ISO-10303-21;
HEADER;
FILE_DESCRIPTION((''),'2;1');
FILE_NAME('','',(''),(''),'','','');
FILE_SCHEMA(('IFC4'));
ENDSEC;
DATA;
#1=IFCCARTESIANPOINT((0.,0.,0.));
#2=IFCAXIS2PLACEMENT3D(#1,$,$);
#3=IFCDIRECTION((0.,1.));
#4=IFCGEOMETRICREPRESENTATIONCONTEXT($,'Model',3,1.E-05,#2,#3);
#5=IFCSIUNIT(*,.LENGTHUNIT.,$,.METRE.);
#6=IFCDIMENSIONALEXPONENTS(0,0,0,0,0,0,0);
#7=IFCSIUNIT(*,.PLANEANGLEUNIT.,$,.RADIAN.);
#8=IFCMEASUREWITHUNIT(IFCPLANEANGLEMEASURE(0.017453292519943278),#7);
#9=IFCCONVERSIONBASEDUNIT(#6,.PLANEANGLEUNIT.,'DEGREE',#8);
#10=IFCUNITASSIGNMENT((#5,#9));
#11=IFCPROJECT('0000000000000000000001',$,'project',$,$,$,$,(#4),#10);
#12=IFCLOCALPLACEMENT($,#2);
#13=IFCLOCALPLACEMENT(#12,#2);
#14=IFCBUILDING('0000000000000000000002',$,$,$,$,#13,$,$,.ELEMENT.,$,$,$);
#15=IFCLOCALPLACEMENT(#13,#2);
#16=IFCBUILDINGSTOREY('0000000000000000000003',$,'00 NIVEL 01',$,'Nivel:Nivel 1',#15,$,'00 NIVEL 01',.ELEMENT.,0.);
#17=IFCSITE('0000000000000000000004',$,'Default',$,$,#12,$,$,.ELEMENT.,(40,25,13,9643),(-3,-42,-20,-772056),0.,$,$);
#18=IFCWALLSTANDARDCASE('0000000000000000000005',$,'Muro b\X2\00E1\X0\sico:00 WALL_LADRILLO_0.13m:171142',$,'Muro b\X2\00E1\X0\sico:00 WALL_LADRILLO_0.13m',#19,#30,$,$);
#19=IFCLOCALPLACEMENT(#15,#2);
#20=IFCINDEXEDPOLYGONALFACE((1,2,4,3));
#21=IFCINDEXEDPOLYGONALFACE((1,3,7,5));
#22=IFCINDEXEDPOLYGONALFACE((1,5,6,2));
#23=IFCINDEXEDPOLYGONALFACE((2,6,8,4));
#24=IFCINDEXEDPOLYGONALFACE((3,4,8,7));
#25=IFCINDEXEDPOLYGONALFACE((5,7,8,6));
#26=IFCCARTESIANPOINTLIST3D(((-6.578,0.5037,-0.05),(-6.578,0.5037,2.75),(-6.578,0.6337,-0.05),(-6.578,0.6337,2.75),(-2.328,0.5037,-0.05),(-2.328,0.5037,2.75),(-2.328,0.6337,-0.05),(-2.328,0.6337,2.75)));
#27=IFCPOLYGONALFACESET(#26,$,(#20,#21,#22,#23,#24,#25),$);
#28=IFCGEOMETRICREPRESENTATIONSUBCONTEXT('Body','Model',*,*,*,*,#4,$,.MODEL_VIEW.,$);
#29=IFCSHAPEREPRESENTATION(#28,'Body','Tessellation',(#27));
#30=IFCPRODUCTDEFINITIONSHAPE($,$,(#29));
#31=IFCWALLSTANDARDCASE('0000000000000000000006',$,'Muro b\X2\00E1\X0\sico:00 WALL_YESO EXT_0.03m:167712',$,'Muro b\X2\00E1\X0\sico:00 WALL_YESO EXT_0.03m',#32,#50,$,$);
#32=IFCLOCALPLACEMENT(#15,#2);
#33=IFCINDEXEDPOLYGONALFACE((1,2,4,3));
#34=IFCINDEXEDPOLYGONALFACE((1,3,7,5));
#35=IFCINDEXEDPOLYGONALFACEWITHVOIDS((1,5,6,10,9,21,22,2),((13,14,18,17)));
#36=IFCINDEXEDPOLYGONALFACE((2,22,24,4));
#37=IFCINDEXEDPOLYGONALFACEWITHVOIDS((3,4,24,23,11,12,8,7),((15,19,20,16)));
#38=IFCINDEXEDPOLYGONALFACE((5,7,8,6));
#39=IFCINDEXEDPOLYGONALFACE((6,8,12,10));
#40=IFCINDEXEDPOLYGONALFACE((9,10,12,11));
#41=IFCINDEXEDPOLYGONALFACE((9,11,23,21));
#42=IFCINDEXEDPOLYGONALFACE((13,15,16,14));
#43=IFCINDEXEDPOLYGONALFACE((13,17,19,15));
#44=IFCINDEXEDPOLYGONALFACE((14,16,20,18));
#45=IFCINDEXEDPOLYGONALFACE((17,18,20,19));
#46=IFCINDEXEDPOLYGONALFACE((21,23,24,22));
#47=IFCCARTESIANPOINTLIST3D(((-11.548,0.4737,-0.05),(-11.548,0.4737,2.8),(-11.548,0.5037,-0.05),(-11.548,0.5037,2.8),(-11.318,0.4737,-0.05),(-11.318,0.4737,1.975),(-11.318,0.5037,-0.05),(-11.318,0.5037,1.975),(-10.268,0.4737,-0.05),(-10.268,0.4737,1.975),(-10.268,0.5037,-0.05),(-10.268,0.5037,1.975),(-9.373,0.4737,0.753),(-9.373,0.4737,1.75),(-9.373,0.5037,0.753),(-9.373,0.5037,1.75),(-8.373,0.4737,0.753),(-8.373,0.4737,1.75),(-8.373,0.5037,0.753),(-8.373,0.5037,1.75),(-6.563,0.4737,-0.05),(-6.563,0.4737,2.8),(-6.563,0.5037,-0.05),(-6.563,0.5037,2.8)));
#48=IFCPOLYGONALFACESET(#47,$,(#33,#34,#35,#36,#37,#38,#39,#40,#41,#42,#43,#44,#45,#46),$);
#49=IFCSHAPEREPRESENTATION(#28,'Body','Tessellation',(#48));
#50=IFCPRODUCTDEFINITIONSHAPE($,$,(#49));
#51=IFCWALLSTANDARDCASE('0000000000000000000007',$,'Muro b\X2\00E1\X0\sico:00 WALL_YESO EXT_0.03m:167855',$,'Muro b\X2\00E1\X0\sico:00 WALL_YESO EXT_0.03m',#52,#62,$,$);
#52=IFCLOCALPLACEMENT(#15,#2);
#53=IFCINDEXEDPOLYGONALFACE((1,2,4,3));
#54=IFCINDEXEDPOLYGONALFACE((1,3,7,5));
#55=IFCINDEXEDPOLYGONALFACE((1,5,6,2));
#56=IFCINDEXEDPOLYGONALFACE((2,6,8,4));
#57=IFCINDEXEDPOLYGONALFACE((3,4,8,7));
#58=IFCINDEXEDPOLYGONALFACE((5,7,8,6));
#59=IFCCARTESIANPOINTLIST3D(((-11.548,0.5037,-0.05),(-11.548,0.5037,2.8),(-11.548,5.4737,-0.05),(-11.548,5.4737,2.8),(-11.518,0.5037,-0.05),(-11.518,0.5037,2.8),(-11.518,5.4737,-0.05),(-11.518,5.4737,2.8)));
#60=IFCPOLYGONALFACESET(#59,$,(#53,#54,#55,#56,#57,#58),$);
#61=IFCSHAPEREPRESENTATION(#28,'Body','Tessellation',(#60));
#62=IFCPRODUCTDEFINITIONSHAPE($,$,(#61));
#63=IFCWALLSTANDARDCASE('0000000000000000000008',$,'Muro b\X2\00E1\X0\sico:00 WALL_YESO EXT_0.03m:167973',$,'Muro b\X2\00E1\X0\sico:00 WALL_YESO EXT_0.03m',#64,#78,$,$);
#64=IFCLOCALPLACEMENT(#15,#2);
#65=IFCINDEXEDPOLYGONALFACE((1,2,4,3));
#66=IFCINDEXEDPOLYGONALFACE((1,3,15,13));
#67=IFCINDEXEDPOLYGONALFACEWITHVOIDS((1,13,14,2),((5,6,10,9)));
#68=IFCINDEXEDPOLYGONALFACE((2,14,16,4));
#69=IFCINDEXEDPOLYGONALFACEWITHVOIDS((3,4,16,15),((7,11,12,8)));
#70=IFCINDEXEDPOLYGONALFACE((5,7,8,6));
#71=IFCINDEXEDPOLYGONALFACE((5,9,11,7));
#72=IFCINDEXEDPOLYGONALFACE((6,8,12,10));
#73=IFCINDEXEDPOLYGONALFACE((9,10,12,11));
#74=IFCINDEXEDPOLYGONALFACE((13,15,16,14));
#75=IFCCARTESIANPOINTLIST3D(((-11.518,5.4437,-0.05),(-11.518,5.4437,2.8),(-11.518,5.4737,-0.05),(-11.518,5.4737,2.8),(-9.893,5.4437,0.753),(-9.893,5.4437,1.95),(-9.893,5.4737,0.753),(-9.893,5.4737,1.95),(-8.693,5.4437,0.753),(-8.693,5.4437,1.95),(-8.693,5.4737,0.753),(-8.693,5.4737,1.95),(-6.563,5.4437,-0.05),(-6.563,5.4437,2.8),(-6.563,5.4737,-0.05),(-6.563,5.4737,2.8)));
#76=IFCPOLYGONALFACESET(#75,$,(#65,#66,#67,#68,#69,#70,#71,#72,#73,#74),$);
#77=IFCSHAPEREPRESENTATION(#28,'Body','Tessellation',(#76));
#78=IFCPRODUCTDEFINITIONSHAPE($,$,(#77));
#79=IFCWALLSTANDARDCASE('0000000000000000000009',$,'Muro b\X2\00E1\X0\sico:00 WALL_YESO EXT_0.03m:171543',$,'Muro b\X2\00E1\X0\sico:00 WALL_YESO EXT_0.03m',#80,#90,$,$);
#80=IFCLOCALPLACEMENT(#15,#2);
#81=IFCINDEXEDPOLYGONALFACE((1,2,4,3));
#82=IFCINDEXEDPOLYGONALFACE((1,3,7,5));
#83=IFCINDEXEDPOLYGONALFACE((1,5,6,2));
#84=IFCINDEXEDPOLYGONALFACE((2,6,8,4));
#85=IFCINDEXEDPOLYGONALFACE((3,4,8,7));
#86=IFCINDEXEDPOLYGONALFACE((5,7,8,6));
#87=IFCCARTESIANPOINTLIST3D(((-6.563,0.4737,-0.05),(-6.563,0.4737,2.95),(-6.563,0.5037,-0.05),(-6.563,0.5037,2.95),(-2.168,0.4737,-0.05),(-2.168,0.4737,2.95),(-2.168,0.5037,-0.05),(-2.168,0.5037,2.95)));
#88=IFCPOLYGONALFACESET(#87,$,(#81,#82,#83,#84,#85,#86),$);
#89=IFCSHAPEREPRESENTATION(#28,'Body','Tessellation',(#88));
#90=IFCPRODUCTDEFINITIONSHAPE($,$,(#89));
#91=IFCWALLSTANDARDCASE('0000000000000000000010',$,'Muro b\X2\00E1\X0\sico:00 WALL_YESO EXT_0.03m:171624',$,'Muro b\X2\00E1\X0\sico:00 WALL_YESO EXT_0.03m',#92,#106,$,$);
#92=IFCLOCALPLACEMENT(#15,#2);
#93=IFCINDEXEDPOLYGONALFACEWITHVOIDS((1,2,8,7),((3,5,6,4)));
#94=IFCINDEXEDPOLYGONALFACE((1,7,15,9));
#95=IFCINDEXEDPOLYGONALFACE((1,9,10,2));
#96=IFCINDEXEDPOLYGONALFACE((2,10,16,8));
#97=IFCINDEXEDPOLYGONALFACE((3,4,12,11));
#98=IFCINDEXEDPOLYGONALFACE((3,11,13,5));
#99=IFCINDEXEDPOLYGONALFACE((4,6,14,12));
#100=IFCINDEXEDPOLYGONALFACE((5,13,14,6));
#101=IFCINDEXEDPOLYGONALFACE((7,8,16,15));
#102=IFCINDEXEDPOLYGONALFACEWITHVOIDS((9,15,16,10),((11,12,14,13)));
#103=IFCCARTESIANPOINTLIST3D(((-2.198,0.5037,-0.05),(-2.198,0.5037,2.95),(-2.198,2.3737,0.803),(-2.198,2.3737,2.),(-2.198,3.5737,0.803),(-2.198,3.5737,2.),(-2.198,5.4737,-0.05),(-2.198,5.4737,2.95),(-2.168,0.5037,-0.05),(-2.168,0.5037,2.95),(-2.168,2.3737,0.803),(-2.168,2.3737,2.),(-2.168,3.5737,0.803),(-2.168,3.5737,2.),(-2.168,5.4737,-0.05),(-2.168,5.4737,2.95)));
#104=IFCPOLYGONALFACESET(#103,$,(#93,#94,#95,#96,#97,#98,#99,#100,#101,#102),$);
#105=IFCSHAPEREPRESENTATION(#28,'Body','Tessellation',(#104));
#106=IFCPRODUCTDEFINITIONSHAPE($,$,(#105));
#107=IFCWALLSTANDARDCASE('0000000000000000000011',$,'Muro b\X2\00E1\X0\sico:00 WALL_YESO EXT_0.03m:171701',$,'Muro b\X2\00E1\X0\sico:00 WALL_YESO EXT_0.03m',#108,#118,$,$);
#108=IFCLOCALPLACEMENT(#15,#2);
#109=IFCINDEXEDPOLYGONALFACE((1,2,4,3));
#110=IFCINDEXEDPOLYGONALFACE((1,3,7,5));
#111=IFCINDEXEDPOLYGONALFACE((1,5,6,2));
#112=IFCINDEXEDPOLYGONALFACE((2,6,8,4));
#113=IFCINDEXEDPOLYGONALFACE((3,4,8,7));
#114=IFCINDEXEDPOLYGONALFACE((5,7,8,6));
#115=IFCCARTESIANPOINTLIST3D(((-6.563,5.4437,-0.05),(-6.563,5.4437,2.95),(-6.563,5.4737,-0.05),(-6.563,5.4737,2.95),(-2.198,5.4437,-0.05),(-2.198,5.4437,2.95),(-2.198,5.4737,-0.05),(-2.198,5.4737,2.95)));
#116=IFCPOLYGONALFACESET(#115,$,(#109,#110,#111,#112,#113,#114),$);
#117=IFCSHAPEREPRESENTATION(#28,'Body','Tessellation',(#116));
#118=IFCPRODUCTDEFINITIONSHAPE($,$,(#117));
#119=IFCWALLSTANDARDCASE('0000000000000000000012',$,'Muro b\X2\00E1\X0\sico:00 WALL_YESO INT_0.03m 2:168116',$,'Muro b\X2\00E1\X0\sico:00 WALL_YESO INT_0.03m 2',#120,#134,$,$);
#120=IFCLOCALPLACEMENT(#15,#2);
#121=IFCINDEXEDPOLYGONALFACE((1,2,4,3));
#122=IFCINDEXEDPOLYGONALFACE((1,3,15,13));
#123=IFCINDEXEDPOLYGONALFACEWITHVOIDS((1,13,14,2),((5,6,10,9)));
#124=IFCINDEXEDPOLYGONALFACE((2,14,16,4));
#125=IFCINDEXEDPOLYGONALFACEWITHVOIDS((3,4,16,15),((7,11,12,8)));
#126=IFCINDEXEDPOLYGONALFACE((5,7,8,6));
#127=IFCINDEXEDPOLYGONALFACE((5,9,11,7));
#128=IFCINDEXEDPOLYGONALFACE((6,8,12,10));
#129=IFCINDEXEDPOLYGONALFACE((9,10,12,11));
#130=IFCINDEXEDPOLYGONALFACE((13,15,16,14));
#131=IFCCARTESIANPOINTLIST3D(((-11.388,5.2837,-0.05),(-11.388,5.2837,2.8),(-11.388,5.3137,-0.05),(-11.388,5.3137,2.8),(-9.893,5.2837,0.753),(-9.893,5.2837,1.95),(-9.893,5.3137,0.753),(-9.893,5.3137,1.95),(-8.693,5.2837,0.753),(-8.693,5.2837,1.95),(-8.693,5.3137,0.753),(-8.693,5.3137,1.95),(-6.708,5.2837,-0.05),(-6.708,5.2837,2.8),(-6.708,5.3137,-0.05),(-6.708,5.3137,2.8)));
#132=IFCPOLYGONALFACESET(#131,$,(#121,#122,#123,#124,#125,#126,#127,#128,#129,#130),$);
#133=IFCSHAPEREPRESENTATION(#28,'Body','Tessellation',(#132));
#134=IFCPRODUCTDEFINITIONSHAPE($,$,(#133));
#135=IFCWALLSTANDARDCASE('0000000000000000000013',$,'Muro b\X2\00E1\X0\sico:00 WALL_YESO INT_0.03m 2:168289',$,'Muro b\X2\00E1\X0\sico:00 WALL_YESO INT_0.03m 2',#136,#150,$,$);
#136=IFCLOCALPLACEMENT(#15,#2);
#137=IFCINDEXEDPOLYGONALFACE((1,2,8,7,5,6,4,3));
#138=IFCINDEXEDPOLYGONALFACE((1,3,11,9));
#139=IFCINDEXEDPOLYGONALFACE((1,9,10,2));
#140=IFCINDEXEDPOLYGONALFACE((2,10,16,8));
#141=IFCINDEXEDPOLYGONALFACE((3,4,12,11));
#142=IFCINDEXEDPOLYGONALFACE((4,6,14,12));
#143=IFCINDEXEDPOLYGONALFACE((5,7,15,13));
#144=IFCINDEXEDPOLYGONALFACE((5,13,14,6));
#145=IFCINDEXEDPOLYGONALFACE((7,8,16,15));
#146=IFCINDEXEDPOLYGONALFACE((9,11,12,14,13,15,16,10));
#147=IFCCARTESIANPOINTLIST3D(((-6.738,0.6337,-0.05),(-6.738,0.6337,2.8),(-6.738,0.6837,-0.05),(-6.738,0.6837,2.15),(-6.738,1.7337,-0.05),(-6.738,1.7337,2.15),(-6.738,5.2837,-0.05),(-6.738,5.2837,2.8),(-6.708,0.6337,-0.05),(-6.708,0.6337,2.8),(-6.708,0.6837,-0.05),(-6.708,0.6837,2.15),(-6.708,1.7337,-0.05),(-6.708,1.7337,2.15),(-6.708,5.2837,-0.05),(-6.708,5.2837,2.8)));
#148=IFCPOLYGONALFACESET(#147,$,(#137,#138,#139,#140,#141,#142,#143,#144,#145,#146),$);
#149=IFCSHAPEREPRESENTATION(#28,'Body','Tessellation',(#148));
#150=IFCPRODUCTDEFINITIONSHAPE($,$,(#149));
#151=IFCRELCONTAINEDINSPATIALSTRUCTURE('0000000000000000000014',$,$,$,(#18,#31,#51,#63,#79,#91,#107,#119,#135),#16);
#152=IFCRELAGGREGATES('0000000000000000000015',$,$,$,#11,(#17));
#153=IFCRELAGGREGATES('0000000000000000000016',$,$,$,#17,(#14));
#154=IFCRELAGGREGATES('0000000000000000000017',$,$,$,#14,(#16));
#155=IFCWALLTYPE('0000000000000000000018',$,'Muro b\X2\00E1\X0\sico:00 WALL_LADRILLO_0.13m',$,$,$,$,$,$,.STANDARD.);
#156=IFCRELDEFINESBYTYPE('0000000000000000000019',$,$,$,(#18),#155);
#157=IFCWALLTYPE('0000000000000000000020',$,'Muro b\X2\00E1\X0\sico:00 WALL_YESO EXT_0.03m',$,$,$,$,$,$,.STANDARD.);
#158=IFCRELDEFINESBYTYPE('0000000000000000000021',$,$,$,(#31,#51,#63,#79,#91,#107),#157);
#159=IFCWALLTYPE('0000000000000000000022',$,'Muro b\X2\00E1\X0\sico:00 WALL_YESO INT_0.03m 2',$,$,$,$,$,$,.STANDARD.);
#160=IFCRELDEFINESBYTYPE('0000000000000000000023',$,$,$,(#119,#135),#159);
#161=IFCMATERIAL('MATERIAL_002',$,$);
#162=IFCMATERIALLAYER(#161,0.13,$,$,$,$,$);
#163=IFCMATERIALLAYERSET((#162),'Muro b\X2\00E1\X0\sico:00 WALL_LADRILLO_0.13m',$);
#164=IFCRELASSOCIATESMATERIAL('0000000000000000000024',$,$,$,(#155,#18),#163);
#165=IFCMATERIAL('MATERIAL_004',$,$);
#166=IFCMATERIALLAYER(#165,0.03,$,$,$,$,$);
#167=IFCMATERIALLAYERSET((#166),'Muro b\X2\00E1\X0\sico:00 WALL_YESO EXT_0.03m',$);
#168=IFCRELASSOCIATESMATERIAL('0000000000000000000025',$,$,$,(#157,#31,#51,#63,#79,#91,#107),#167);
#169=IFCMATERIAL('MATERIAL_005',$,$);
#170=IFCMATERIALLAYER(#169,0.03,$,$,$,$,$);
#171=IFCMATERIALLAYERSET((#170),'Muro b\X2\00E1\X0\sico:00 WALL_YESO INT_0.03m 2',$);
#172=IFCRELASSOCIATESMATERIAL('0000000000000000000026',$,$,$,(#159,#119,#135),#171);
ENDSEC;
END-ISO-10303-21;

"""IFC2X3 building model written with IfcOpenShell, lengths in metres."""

from ifc_helpers import new_model, entity, si_unit, converted_unit, direction, frame, frame_2d, origin, place, context, subcontext, project, spatial, rectangle, extrude, material, layer, layer_set, layer_usage, type_object, element, save


model = new_model("IFC2X3")

# Units and contexts
model_context = context("Model", 3, precision=1e-05, world=origin(), true_north=direction((0.0, 1.0)))
body_context = subcontext(model_context, "Body", "Model", "MODEL_VIEW")
ifc_project = project(units=[si_unit("LENGTHUNIT", "METRE"), converted_unit("PLANEANGLEUNIT", "DEGREE", entity("IfcPlaneAngleMeasure", 0.017453292519943278), si_unit("PLANEANGLEUNIT", "RADIAN"), dimensions=[0, 0, 0, 0, 0, 0, 0])], contexts=[model_context])

# Site, building, storey
site_placement = place(None, origin())
site = spatial("IfcSite", under=ifc_project, at=site_placement, Name="Default", CompositionType="ELEMENT", RefLatitude=(40, 25, 13, 9643), RefLongitude=(-3, -42, -20, -772056), RefElevation=0.0)
building_placement = place(site_placement, origin())
building = spatial("IfcBuilding", under=site, at=building_placement, CompositionType="ELEMENT")
storey_placement = place(building_placement, origin())
storey = spatial("IfcBuildingStorey", under=building, at=storey_placement, Name="00 NIVEL 01", ObjectType="Nivel:Nivel 1", LongName="00 NIVEL 01", CompositionType="ELEMENT", Elevation=0.0)

# Shared definitions
ifc_material_1 = material(Name="MATERIAL_002")
ifc_layer_1 = layer(ifc_material_1, 0.13)
ifc_layer_set_1 = layer_set([ifc_layer_1], Name="Muro básico:00 WALL_LADRILLO_0.13m")
wall_type_1 = type_object("IfcWallType", Name="Muro básico:00 WALL_LADRILLO_0.13m", PredefinedType="STANDARD", material=ifc_layer_set_1)

# Wall
ifc_layer_usage_1 = layer_usage(ifc_layer_set_1, "AXIS2", "POSITIVE", -0.065)
wall_1_placement = place(storey_placement, frame((-6.578, 0.5687, -0.05)))
element("IfcWallStandardCase", 1, at=wall_1_placement, inside=storey, type_object=wall_type_1, material=ifc_layer_usage_1, Name="Muro básico:00 WALL_LADRILLO_0.13m:171142", ObjectType="Muro básico:00 WALL_LADRILLO_0.13m", context=body_context, shape_type="SweptSolid", body=[
    extrude(rectangle(XDim=4.25, YDim=0.13, at=frame_2d((2.125, 0.0), x_axis=(-1.0, 0.0))), origin(), (0.0, 0.0, 1.0), 2.8),
])

# Wall, openings
ifc_material_2 = material(Name="MATERIAL_004")
ifc_layer_2 = layer(ifc_material_2, 0.03)
ifc_layer_set_2 = layer_set([ifc_layer_2], Name="Muro básico:00 WALL_YESO EXT_0.03m")
ifc_layer_usage_2 = layer_usage(ifc_layer_set_2, "AXIS2", "POSITIVE", -0.015)
wall_type_2 = type_object("IfcWallType", Name="Muro básico:00 WALL_YESO EXT_0.03m", PredefinedType="STANDARD", material=ifc_layer_set_2)
wall_2_placement = place(storey_placement, frame((-11.548, 0.4887, -0.05)))
wall_2 = element("IfcWallStandardCase", 2, at=wall_2_placement, inside=storey, type_object=wall_type_2, material=ifc_layer_usage_2, Name="Muro básico:00 WALL_YESO EXT_0.03m:167712", ObjectType="Muro básico:00 WALL_YESO EXT_0.03m", context=body_context, shape_type="SweptSolid", body=[
    extrude(rectangle(XDim=4.985, YDim=0.03, at=frame_2d((2.4925, 0.0), x_axis=(-1.0, 0.0))), origin(), (0.0, 0.0, 1.0), 2.85),
])
opening_1_placement = place(wall_2_placement, origin())
element("IfcOpeningElement", 3, at=opening_1_placement, cuts=wall_2, ObjectType="Opening", context=body_context, shape_type="SweptSolid", body=[
    extrude(rectangle(XDim=0.997, YDim=1.0, at=frame_2d((0.0, 0.0), x_axis=(0.0, 1.0))), frame((2.675, 0.015, 1.3015), z_axis=(0.0, -1.0, 0.0), x_axis=(1.0, 0.0, 0.0)), (0.0, 0.0, 1.0), 0.03),
])
opening_2_placement = place(wall_2_placement, origin())
element("IfcOpeningElement", 4, at=opening_2_placement, cuts=wall_2, ObjectType="Opening", context=body_context, shape_type="SweptSolid", body=[
    extrude(rectangle(XDim=2.025, YDim=1.05, at=frame_2d((0.0, 0.0), x_axis=(0.0, 1.0))), frame((0.755, 0.015, 1.0125), z_axis=(0.0, -1.0, 0.0), x_axis=(1.0, 0.0, 0.0)), (0.0, 0.0, 1.0), 0.03),
])

# Wall
ifc_layer_usage_3 = layer_usage(ifc_layer_set_2, "AXIS2", "NEGATIVE", 0.015)
wall_3_placement = place(storey_placement, frame((-11.533, 0.5037, -0.05), z_axis=(0.0, 0.0, 1.0), x_axis=(0.0, 1.0, 0.0)))
element("IfcWallStandardCase", 5, at=wall_3_placement, inside=storey, type_object=wall_type_2, material=ifc_layer_usage_3, Name="Muro básico:00 WALL_YESO EXT_0.03m:167855", ObjectType="Muro básico:00 WALL_YESO EXT_0.03m", context=body_context, shape_type="SweptSolid", body=[
    extrude(rectangle(XDim=4.97, YDim=0.03, at=frame_2d((2.485, 0.0), x_axis=(-1.0, 0.0))), origin(), (0.0, 0.0, 1.0), 2.85),
])

# Wall, opening
ifc_layer_usage_4 = layer_usage(ifc_layer_set_2, "AXIS2", "NEGATIVE", 0.015)
wall_4_placement = place(storey_placement, frame((-11.518, 5.4587, -0.05)))
wall_4 = element("IfcWallStandardCase", 6, at=wall_4_placement, inside=storey, type_object=wall_type_2, material=ifc_layer_usage_4, Name="Muro básico:00 WALL_YESO EXT_0.03m:167973", ObjectType="Muro básico:00 WALL_YESO EXT_0.03m", context=body_context, shape_type="SweptSolid", body=[
    extrude(rectangle(XDim=4.955, YDim=0.03, at=frame_2d((2.4775, 0.0), x_axis=(-1.0, 0.0))), origin(), (0.0, 0.0, 1.0), 2.85),
])
opening_3_placement = place(wall_4_placement, origin())
element("IfcOpeningElement", 7, at=opening_3_placement, cuts=wall_4, ObjectType="Opening", context=body_context, shape_type="SweptSolid", body=[
    extrude(rectangle(XDim=1.197, YDim=1.2, at=frame_2d((0.0, 0.0), x_axis=(1.0, 0.0))), frame((2.225, 0.015, 1.4015), z_axis=(0.0, -1.0, 0.0), x_axis=(0.0, 0.0, -1.0)), (0.0, 0.0, 1.0), 0.03),
])

# Wall
ifc_layer_usage_5 = layer_usage(ifc_layer_set_2, "AXIS2", "NEGATIVE", 0.015)
wall_5_placement = place(storey_placement, frame((-6.563, 0.4887, -0.05)))
element("IfcWallStandardCase", 8, at=wall_5_placement, inside=storey, type_object=wall_type_2, material=ifc_layer_usage_5, Name="Muro básico:00 WALL_YESO EXT_0.03m:171543", ObjectType="Muro básico:00 WALL_YESO EXT_0.03m", context=body_context, shape_type="SweptSolid", body=[
    extrude(rectangle(XDim=4.395, YDim=0.03, at=frame_2d((2.1975, 0.0), x_axis=(-1.0, 0.0))), origin(), (0.0, 0.0, 1.0), 3.0),
])

# Wall, opening
ifc_layer_usage_6 = layer_usage(ifc_layer_set_2, "AXIS2", "NEGATIVE", 0.015)
wall_6_placement = place(storey_placement, frame((-2.183, 0.5037, -0.05), z_axis=(0.0, 0.0, 1.0), x_axis=(0.0, 1.0, 0.0)))
wall_6 = element("IfcWallStandardCase", 9, at=wall_6_placement, inside=storey, type_object=wall_type_2, material=ifc_layer_usage_6, Name="Muro básico:00 WALL_YESO EXT_0.03m:171624", ObjectType="Muro básico:00 WALL_YESO EXT_0.03m", context=body_context, shape_type="SweptSolid", body=[
    extrude(rectangle(XDim=4.97, YDim=0.03, at=frame_2d((2.485, 0.0), x_axis=(-1.0, 0.0))), origin(), (0.0, 0.0, 1.0), 3.0),
])
opening_4_placement = place(wall_6_placement, origin())
element("IfcOpeningElement", 10, at=opening_4_placement, cuts=wall_6, ObjectType="Opening", context=body_context, shape_type="SweptSolid", body=[
    extrude(rectangle(XDim=1.197, YDim=1.2, at=frame_2d((0.0, 0.0), x_axis=(0.0, 1.0))), frame((2.47, 0.015, 1.4515), z_axis=(0.0, -1.0, 0.0), x_axis=(-1.0, 0.0, 0.0)), (0.0, 0.0, 1.0), 0.03),
])

# Wall
ifc_layer_usage_7 = layer_usage(ifc_layer_set_2, "AXIS2", "NEGATIVE", 0.015)
wall_7_placement = place(storey_placement, frame((-2.198, 5.4587, -0.05), z_axis=(0.0, 0.0, 1.0), x_axis=(-1.0, 0.0, 0.0)))
element("IfcWallStandardCase", 11, at=wall_7_placement, inside=storey, type_object=wall_type_2, material=ifc_layer_usage_7, Name="Muro básico:00 WALL_YESO EXT_0.03m:171701", ObjectType="Muro básico:00 WALL_YESO EXT_0.03m", context=body_context, shape_type="SweptSolid", body=[
    extrude(rectangle(XDim=4.365, YDim=0.03, at=frame_2d((2.1825, 0.0), x_axis=(-1.0, 0.0))), origin(), (0.0, 0.0, 1.0), 3.0),
])

# Walls, openings
ifc_material_3 = material(Name="MATERIAL_005")
ifc_layer_3 = layer(ifc_material_3, 0.03)
ifc_layer_set_3 = layer_set([ifc_layer_3], Name="Muro básico:00 WALL_YESO INT_0.03m 2")
ifc_layer_usage_8 = layer_usage(ifc_layer_set_3, "AXIS2", "NEGATIVE", 0.015)
wall_type_3 = type_object("IfcWallType", Name="Muro básico:00 WALL_YESO INT_0.03m 2", PredefinedType="STANDARD", material=ifc_layer_set_3)
wall_8_placement = place(storey_placement, frame((-11.388, 5.2987, -0.05)))
wall_8 = element("IfcWallStandardCase", 12, at=wall_8_placement, inside=storey, type_object=wall_type_3, material=ifc_layer_usage_8, Name="Muro básico:00 WALL_YESO INT_0.03m 2:168116", ObjectType="Muro básico:00 WALL_YESO INT_0.03m 2", context=body_context, shape_type="SweptSolid", body=[
    extrude(rectangle(XDim=4.68, YDim=0.03, at=frame_2d((2.34, 0.0), x_axis=(-1.0, 0.0))), origin(), (0.0, 0.0, 1.0), 2.85),
])
opening_5_placement = place(wall_8_placement, origin())
element("IfcOpeningElement", 13, at=opening_5_placement, cuts=wall_8, ObjectType="Opening", context=body_context, shape_type="SweptSolid", body=[
    extrude(rectangle(XDim=1.197, YDim=1.2, at=frame_2d((0.0, 0.0), x_axis=(1.0, 0.0))), frame((2.095, 0.015, 1.4015), z_axis=(0.0, -1.0, 0.0), x_axis=(0.0, 0.0, 1.0)), (0.0, 0.0, 1.0), 0.03),
])
ifc_layer_usage_9 = layer_usage(ifc_layer_set_3, "AXIS2", "NEGATIVE", 0.015)
wall_9_placement = place(storey_placement, frame((-6.723, 5.2837, -0.05), z_axis=(0.0, 0.0, 1.0), x_axis=(0.0, -1.0, 0.0)))
wall_9 = element("IfcWallStandardCase", 14, at=wall_9_placement, inside=storey, type_object=wall_type_3, material=ifc_layer_usage_9, Name="Muro básico:00 WALL_YESO INT_0.03m 2:168289", ObjectType="Muro básico:00 WALL_YESO INT_0.03m 2", context=body_context, shape_type="SweptSolid", body=[
    extrude(rectangle(XDim=4.65, YDim=0.03, at=frame_2d((2.325, 0.0), x_axis=(-1.0, 0.0))), origin(), (0.0, 0.0, 1.0), 2.85),
])
opening_6_placement = place(wall_9_placement, origin())
element("IfcOpeningElement", 15, at=opening_6_placement, cuts=wall_9, ObjectType="Opening", context=body_context, shape_type="SweptSolid", body=[
    extrude(rectangle(XDim=2.2, YDim=1.05, at=frame_2d((0.0, 0.0), x_axis=(0.0, 1.0))), frame((4.075, 0.015, 1.1), z_axis=(0.0, -1.0, 0.0), x_axis=(1.0, 0.0, 0.0)), (0.0, 0.0, 1.0), 0.03),
])

save(model, "model.ifc")
